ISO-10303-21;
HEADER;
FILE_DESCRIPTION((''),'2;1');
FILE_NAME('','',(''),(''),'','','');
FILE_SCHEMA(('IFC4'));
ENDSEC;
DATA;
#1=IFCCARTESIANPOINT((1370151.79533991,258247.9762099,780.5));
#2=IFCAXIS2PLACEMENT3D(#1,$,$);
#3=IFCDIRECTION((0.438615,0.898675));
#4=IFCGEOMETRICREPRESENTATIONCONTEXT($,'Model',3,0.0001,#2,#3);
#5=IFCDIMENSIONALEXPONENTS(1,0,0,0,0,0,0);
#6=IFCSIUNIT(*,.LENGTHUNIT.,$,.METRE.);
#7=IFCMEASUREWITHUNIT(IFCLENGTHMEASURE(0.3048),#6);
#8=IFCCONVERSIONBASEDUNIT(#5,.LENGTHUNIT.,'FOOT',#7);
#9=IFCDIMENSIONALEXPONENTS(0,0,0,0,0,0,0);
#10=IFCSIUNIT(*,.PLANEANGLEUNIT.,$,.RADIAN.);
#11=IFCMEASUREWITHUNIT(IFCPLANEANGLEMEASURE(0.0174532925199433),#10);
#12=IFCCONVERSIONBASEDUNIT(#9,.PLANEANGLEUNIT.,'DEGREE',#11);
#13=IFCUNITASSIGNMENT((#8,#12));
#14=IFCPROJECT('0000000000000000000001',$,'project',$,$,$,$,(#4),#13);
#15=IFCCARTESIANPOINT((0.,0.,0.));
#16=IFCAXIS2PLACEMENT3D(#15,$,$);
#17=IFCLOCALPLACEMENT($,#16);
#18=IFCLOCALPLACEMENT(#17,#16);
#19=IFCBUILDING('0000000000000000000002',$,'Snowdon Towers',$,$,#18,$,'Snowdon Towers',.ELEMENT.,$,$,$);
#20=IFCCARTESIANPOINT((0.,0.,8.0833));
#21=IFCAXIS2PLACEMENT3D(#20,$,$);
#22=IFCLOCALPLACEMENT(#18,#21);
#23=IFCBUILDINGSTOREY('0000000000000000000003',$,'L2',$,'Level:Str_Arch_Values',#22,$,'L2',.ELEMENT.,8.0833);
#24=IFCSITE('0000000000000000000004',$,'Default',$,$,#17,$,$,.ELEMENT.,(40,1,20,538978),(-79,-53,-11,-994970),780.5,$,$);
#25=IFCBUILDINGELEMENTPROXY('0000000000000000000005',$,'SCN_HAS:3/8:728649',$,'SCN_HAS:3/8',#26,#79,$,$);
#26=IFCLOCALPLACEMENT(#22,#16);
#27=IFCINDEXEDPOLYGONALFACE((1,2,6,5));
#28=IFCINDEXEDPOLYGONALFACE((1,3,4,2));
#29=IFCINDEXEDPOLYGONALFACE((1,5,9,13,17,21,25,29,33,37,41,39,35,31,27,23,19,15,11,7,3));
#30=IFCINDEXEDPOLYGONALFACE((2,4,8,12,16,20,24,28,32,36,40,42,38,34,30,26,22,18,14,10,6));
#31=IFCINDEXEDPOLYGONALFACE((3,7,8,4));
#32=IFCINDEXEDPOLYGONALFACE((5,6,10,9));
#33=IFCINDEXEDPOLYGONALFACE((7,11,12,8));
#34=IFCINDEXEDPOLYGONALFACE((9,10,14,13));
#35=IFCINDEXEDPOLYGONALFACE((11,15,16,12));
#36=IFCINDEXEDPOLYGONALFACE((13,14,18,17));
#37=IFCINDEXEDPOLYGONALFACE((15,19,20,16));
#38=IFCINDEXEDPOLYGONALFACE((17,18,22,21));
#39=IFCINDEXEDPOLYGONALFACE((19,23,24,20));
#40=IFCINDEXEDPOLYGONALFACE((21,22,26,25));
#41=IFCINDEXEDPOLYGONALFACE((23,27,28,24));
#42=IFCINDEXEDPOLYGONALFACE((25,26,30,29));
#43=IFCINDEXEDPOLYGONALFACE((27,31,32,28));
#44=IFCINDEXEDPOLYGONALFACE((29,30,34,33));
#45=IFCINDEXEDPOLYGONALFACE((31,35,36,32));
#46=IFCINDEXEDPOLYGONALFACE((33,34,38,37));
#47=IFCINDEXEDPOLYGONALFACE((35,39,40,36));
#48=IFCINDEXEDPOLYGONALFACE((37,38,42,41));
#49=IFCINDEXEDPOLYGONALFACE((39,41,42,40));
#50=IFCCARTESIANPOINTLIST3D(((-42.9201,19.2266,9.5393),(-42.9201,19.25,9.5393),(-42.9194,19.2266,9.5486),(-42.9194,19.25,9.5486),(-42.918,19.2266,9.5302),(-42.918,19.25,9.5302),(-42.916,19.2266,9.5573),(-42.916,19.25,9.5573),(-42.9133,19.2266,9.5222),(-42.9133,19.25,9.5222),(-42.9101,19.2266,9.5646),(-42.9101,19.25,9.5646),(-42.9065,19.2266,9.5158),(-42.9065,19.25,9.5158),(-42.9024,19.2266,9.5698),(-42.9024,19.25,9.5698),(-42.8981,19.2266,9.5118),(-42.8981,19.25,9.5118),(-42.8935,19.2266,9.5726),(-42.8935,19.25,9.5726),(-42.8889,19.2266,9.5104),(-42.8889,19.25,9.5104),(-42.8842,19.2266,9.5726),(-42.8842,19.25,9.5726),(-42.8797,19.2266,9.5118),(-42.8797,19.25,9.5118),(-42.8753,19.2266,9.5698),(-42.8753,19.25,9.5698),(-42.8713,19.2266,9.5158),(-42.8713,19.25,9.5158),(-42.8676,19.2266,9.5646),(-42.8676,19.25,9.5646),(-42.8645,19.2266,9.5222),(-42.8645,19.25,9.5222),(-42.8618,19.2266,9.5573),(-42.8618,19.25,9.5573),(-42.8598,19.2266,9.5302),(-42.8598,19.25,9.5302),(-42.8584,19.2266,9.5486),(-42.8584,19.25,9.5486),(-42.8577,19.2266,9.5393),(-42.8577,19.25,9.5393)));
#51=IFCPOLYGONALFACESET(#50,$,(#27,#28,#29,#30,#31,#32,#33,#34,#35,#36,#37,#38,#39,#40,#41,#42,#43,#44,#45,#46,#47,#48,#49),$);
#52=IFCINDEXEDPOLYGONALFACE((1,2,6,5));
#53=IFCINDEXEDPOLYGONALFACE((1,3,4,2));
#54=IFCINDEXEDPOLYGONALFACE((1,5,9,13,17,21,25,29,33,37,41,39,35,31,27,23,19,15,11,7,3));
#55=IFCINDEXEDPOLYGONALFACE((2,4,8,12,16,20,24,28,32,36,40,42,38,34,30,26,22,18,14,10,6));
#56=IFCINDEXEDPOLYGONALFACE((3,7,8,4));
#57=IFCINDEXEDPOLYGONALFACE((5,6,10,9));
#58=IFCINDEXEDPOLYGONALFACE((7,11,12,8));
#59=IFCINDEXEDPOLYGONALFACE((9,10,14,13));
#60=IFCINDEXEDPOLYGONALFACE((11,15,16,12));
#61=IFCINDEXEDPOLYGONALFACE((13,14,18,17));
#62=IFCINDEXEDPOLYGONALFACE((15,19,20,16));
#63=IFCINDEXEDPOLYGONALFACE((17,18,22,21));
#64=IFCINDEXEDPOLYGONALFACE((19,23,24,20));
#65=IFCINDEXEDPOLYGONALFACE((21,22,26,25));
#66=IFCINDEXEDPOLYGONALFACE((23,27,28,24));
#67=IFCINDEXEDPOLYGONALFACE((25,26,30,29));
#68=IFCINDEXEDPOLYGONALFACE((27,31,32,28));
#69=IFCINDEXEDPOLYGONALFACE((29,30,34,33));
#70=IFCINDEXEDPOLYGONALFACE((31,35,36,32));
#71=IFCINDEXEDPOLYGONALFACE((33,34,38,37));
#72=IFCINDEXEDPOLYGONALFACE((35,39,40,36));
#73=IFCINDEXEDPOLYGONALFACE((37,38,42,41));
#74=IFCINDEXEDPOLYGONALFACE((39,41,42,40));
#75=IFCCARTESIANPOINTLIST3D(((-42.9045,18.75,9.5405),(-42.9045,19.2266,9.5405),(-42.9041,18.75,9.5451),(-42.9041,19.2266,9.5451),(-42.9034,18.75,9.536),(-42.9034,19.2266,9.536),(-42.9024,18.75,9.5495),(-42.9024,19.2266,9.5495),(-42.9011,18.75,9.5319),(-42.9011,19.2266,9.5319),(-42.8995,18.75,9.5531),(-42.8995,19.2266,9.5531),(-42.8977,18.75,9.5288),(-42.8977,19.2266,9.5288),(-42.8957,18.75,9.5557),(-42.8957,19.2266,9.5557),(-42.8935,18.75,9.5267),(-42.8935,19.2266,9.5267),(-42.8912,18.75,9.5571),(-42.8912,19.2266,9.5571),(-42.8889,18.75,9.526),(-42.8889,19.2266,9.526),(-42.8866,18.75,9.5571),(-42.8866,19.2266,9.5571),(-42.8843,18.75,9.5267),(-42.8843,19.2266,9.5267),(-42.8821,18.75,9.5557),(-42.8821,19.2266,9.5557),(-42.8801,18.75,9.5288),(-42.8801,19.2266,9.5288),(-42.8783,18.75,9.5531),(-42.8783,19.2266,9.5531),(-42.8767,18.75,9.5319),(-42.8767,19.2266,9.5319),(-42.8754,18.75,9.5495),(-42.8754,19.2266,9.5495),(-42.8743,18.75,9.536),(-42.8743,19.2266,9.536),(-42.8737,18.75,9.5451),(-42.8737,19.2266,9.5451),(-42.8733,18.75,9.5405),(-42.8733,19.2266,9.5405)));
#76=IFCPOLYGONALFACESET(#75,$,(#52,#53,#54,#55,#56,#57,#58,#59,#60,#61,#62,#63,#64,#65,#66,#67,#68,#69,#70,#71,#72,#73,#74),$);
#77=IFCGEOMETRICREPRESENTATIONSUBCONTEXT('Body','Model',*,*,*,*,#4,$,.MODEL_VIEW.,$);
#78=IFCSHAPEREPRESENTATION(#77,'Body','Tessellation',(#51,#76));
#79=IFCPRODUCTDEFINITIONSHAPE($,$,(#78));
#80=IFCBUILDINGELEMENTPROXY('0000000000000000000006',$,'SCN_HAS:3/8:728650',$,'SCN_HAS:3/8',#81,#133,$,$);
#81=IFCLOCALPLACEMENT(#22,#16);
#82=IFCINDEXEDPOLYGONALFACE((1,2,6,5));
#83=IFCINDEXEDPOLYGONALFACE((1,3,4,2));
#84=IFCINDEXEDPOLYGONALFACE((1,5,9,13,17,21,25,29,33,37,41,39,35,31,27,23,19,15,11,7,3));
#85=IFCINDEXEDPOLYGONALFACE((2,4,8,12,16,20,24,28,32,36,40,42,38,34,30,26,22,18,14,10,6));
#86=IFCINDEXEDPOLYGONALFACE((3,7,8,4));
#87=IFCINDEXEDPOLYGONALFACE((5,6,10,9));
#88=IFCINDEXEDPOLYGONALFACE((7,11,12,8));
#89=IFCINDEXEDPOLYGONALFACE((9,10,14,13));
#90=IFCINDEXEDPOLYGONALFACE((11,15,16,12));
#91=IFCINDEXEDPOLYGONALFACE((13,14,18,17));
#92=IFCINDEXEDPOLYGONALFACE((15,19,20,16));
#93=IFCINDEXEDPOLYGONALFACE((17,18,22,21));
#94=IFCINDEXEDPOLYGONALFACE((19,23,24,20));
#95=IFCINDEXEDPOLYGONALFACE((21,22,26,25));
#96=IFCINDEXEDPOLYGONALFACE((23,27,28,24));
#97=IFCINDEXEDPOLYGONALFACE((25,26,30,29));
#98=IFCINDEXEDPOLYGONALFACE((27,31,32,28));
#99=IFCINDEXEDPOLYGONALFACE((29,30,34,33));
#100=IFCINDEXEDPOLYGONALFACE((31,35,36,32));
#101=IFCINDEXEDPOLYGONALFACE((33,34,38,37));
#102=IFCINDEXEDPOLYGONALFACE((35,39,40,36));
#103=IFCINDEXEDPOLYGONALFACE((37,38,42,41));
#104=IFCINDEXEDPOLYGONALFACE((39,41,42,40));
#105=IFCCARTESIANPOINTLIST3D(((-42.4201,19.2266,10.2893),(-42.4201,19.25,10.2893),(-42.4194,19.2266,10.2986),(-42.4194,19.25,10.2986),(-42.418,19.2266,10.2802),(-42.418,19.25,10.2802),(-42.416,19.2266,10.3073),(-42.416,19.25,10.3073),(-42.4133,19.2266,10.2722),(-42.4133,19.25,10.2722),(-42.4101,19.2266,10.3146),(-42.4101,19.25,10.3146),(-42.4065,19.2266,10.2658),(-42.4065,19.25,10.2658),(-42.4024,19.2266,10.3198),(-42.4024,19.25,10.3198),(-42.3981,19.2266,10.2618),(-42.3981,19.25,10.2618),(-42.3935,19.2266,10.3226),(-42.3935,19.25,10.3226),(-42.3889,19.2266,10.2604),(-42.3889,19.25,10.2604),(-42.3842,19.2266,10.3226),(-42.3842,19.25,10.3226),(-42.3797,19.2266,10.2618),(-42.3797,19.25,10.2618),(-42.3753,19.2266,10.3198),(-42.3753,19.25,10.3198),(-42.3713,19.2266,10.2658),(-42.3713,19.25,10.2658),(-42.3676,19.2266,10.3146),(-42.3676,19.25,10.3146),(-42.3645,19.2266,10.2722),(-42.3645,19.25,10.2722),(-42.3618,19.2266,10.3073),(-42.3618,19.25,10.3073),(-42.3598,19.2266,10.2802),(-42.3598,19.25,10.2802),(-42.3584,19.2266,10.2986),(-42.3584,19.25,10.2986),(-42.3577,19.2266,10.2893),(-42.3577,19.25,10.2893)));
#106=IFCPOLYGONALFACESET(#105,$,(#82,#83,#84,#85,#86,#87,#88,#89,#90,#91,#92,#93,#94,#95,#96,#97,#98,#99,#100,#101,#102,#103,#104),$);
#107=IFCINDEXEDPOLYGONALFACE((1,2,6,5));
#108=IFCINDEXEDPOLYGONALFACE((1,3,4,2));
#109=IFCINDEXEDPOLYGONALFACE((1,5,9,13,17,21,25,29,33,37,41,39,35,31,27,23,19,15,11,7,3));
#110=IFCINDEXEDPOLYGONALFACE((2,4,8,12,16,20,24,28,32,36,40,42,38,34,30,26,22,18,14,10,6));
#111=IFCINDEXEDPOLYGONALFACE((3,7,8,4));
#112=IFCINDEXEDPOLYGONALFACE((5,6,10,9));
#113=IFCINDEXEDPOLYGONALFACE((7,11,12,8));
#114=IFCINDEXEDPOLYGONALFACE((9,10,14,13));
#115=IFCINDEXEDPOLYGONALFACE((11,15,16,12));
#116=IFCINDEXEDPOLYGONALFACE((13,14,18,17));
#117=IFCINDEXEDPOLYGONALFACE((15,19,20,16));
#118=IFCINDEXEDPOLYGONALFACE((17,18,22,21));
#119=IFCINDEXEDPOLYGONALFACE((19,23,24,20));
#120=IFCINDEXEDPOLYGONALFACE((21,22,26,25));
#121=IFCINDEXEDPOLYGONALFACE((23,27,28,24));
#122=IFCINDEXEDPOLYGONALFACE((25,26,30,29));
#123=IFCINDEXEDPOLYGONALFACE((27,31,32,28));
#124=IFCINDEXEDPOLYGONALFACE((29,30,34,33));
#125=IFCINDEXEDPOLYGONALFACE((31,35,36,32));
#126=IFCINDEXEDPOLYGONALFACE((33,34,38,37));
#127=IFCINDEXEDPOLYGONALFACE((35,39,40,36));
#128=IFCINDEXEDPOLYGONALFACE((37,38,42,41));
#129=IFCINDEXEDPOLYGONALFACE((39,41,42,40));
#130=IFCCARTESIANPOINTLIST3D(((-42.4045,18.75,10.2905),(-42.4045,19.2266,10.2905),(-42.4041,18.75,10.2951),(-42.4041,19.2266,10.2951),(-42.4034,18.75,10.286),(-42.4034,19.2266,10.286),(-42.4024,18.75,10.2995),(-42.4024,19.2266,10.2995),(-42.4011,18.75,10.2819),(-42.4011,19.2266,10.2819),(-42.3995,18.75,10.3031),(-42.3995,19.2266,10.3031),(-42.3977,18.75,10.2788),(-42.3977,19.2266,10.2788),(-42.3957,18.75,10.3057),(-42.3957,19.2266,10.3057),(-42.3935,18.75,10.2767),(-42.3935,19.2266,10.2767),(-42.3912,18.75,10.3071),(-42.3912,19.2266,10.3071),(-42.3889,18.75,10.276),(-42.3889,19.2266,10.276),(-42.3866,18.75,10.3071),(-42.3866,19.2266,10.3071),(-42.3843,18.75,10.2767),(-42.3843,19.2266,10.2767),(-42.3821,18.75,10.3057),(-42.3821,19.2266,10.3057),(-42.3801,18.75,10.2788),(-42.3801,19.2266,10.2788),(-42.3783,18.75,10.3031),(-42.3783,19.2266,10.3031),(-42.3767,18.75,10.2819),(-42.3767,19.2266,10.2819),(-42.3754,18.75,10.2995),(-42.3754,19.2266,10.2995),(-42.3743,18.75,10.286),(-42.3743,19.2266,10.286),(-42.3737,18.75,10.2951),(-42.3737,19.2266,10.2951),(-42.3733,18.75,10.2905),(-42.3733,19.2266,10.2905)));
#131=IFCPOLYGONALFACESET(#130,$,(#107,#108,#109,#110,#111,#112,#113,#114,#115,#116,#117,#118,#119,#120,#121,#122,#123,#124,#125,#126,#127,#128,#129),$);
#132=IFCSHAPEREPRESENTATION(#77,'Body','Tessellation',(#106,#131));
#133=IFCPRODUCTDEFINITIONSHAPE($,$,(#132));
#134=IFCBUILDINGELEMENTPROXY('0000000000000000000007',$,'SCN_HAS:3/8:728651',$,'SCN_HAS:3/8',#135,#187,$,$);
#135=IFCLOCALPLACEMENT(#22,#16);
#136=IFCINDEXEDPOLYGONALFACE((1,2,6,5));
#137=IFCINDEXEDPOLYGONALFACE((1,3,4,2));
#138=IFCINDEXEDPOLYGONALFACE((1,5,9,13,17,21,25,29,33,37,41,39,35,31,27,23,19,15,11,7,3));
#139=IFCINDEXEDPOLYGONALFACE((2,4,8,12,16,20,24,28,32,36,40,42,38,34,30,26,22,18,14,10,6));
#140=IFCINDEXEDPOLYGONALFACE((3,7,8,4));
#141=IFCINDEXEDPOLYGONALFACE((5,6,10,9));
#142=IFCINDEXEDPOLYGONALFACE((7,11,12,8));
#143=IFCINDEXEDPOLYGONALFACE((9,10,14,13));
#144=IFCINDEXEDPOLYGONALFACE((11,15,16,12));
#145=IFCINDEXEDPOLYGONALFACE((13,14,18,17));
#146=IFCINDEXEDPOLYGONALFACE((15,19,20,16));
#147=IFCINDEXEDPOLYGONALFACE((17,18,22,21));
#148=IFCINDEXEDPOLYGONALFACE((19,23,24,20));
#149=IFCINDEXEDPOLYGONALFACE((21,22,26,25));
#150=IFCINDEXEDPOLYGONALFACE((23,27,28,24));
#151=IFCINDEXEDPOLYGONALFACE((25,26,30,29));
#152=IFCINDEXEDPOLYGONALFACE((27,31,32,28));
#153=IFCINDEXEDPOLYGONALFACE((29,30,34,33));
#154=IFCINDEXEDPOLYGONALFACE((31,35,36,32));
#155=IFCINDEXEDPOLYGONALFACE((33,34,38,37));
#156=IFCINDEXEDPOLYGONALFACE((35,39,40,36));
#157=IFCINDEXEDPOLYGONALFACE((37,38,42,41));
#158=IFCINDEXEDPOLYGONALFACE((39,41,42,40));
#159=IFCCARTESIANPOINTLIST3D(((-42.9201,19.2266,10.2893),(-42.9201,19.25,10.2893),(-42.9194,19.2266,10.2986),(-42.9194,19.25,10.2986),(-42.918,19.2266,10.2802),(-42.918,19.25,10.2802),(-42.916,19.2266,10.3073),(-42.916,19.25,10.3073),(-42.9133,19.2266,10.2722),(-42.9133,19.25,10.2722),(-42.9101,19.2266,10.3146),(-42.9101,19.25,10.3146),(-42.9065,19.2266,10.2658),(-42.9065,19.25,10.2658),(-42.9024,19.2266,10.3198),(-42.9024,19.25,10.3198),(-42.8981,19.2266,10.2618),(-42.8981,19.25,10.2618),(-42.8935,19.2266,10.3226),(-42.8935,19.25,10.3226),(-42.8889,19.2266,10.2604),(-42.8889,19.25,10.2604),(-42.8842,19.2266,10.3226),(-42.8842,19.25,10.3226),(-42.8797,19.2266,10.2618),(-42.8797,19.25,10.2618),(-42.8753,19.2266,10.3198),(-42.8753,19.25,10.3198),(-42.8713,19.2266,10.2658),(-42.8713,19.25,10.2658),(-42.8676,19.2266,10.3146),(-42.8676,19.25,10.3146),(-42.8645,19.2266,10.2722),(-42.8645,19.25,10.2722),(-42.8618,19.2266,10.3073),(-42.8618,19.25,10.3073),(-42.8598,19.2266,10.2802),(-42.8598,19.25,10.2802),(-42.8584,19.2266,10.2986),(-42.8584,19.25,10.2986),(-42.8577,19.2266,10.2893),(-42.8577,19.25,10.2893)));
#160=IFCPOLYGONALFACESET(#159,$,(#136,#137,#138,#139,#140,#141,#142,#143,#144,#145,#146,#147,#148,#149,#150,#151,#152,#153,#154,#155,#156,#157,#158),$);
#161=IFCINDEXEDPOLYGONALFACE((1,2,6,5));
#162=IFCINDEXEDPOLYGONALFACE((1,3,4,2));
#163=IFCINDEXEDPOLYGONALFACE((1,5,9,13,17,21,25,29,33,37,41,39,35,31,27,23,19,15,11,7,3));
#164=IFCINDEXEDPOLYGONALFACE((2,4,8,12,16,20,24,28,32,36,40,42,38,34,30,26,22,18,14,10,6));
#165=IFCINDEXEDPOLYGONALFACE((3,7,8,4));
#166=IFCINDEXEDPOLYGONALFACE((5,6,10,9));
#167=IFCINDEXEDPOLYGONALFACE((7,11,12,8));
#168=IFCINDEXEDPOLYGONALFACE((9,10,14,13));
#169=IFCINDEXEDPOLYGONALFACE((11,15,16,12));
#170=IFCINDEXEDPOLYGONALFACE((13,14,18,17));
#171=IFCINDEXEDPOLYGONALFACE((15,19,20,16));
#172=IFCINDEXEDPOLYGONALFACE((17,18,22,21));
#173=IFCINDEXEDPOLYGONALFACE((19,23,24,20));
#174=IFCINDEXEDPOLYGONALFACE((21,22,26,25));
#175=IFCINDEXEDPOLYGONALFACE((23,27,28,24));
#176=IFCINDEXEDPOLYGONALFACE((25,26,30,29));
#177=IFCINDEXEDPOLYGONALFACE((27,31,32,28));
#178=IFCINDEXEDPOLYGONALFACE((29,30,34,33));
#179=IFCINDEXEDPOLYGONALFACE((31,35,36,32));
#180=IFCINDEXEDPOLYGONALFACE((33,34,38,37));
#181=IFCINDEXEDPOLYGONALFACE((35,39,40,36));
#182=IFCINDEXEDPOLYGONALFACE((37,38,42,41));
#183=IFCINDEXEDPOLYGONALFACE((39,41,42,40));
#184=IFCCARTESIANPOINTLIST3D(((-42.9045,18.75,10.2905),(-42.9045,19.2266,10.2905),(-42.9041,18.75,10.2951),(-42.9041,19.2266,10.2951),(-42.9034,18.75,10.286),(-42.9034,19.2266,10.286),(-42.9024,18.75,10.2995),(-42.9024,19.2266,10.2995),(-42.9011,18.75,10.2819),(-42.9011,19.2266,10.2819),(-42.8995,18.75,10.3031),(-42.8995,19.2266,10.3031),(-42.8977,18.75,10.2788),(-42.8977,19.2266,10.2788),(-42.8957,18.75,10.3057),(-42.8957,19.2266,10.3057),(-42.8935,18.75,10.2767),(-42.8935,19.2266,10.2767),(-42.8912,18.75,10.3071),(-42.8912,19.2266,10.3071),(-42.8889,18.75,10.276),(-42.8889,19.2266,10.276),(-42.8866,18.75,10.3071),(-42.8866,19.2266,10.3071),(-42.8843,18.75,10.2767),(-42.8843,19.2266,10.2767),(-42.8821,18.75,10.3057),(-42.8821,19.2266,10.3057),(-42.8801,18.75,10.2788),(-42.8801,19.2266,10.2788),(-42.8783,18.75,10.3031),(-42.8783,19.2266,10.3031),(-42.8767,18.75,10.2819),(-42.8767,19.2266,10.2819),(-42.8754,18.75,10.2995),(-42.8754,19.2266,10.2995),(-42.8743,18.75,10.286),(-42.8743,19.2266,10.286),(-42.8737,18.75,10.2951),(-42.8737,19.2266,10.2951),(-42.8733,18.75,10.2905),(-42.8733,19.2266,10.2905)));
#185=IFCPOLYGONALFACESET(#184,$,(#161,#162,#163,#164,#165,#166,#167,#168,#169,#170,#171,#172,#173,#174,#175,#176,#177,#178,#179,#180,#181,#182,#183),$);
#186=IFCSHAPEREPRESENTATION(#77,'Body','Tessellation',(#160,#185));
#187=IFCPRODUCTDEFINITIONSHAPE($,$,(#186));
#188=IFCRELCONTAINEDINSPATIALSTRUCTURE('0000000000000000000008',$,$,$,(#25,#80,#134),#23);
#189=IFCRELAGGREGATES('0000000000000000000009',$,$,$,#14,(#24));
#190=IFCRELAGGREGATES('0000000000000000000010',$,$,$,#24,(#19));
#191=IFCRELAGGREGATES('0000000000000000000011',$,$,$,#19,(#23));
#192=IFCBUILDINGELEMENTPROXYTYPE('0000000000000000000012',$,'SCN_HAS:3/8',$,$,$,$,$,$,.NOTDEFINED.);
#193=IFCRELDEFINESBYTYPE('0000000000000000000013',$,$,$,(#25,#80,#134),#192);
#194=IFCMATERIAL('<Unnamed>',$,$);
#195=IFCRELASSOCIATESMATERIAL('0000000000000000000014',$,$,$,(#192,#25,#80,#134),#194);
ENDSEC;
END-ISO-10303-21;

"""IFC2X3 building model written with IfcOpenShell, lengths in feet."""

from ifc_helpers import new_model, entity, si_unit, converted_unit, direction, frame, frame_2d, origin, place, context, subcontext, project, spatial, circle, extrude, source, transform, mapped, material, type_object, type_shapes, element, save


model = new_model("IFC2X3")

# Units and contexts
model_context = context("Model", 3, precision=0.0001, world=frame((1370151.79533991, 258247.9762099, 780.5)), true_north=direction((0.438615, 0.898675)))
body_context = subcontext(model_context, "Body", "Model", "MODEL_VIEW")
ifc_project = project(units=[converted_unit("LENGTHUNIT", "FOOT", entity("IfcLengthMeasure", 0.3048), si_unit("LENGTHUNIT", "METRE"), dimensions=[1, 0, 0, 0, 0, 0, 0]), converted_unit("PLANEANGLEUNIT", "DEGREE", entity("IfcPlaneAngleMeasure", 0.0174532925199433), si_unit("PLANEANGLEUNIT", "RADIAN"), dimensions=[0, 0, 0, 0, 0, 0, 0])], contexts=[model_context])

# Site, building, storey
site_placement = place(None, origin())
site = spatial("IfcSite", under=ifc_project, at=site_placement, Name="Default", CompositionType="ELEMENT", RefLatitude=(40, 1, 20, 538978), RefLongitude=(-79, -53, -11, -994970), RefElevation=780.5)
building_placement = place(site_placement, origin())
building = spatial("IfcBuilding", under=site, at=building_placement, Name="Snowdon Towers", LongName="Snowdon Towers", CompositionType="ELEMENT")
storey_placement = place(building_placement, frame((0.0, 0.0, 8.0833)))
storey = spatial("IfcBuildingStorey", under=building, at=storey_placement, Name="L2", ObjectType="Level:Str_Arch_Values", LongName="L2", CompositionType="ELEMENT", Elevation=8.0833)

# Building element proxies
ifc_material_1 = material(Name="<Unnamed>")
building_element_proxy_type_1 = type_object("IfcBuildingElementProxyType", Name="SCN_HAS:3/8", PredefinedType="NOTDEFINED", material=ifc_material_1)
shared_shape_1 = source(origin(), body_context, "Body", "SweptSolid", [
    extrude(circle(Radius=0.0312, at=frame_2d((0.0, 0.0), x_axis=(1.0, 0.0))), frame((0.0, 0.0, -0.5), z_axis=(0.0, 0.0, 1.0), x_axis=(0.0, -1.0, 0.0)), (0.0, 0.0, 1.0), 0.0234),
    extrude(circle(Radius=0.0156, at=frame_2d((0.0, 0.0), x_axis=(1.0, 0.0))), frame((0.0, 0.0, -0.4766), z_axis=(0.0, 0.0, 1.0), x_axis=(0.0, -1.0, 0.0)), (0.0, 0.0, 1.0), 0.4766),
])
type_shapes(building_element_proxy_type_1, [shared_shape_1])
for number, where, z_axis, x_axis, name in (
    (1, (-42.8889, 18.75, 9.5417), (0.0, -1.0, 0.0), (1.0, 0.0, 0.0), "SCN_HAS:3/8:728649"),
    (2, (-42.3889, 18.75, 10.2917), (0.0, -1.0, 0.0), (1.0, 0.0, 0.0), "SCN_HAS:3/8:728650"),
    (3, (-42.8889, 18.75, 10.2917), (0.0, -1.0, 0.0), (1.0, 0.0, 0.0), "SCN_HAS:3/8:728651"),
):
    element("IfcBuildingElementProxy", number, at=place(storey_placement, frame(where, z_axis=z_axis, x_axis=x_axis)), inside=storey, type_object=building_element_proxy_type_1, material=ifc_material_1, Name=name, ObjectType="SCN_HAS:3/8", context=body_context, shape_type="MappedRepresentation", body=[
        mapped(shared_shape_1, transform((0.0, 0.0, 0.0), scale=1.0)),
    ])

save(model, "model.ifc")
